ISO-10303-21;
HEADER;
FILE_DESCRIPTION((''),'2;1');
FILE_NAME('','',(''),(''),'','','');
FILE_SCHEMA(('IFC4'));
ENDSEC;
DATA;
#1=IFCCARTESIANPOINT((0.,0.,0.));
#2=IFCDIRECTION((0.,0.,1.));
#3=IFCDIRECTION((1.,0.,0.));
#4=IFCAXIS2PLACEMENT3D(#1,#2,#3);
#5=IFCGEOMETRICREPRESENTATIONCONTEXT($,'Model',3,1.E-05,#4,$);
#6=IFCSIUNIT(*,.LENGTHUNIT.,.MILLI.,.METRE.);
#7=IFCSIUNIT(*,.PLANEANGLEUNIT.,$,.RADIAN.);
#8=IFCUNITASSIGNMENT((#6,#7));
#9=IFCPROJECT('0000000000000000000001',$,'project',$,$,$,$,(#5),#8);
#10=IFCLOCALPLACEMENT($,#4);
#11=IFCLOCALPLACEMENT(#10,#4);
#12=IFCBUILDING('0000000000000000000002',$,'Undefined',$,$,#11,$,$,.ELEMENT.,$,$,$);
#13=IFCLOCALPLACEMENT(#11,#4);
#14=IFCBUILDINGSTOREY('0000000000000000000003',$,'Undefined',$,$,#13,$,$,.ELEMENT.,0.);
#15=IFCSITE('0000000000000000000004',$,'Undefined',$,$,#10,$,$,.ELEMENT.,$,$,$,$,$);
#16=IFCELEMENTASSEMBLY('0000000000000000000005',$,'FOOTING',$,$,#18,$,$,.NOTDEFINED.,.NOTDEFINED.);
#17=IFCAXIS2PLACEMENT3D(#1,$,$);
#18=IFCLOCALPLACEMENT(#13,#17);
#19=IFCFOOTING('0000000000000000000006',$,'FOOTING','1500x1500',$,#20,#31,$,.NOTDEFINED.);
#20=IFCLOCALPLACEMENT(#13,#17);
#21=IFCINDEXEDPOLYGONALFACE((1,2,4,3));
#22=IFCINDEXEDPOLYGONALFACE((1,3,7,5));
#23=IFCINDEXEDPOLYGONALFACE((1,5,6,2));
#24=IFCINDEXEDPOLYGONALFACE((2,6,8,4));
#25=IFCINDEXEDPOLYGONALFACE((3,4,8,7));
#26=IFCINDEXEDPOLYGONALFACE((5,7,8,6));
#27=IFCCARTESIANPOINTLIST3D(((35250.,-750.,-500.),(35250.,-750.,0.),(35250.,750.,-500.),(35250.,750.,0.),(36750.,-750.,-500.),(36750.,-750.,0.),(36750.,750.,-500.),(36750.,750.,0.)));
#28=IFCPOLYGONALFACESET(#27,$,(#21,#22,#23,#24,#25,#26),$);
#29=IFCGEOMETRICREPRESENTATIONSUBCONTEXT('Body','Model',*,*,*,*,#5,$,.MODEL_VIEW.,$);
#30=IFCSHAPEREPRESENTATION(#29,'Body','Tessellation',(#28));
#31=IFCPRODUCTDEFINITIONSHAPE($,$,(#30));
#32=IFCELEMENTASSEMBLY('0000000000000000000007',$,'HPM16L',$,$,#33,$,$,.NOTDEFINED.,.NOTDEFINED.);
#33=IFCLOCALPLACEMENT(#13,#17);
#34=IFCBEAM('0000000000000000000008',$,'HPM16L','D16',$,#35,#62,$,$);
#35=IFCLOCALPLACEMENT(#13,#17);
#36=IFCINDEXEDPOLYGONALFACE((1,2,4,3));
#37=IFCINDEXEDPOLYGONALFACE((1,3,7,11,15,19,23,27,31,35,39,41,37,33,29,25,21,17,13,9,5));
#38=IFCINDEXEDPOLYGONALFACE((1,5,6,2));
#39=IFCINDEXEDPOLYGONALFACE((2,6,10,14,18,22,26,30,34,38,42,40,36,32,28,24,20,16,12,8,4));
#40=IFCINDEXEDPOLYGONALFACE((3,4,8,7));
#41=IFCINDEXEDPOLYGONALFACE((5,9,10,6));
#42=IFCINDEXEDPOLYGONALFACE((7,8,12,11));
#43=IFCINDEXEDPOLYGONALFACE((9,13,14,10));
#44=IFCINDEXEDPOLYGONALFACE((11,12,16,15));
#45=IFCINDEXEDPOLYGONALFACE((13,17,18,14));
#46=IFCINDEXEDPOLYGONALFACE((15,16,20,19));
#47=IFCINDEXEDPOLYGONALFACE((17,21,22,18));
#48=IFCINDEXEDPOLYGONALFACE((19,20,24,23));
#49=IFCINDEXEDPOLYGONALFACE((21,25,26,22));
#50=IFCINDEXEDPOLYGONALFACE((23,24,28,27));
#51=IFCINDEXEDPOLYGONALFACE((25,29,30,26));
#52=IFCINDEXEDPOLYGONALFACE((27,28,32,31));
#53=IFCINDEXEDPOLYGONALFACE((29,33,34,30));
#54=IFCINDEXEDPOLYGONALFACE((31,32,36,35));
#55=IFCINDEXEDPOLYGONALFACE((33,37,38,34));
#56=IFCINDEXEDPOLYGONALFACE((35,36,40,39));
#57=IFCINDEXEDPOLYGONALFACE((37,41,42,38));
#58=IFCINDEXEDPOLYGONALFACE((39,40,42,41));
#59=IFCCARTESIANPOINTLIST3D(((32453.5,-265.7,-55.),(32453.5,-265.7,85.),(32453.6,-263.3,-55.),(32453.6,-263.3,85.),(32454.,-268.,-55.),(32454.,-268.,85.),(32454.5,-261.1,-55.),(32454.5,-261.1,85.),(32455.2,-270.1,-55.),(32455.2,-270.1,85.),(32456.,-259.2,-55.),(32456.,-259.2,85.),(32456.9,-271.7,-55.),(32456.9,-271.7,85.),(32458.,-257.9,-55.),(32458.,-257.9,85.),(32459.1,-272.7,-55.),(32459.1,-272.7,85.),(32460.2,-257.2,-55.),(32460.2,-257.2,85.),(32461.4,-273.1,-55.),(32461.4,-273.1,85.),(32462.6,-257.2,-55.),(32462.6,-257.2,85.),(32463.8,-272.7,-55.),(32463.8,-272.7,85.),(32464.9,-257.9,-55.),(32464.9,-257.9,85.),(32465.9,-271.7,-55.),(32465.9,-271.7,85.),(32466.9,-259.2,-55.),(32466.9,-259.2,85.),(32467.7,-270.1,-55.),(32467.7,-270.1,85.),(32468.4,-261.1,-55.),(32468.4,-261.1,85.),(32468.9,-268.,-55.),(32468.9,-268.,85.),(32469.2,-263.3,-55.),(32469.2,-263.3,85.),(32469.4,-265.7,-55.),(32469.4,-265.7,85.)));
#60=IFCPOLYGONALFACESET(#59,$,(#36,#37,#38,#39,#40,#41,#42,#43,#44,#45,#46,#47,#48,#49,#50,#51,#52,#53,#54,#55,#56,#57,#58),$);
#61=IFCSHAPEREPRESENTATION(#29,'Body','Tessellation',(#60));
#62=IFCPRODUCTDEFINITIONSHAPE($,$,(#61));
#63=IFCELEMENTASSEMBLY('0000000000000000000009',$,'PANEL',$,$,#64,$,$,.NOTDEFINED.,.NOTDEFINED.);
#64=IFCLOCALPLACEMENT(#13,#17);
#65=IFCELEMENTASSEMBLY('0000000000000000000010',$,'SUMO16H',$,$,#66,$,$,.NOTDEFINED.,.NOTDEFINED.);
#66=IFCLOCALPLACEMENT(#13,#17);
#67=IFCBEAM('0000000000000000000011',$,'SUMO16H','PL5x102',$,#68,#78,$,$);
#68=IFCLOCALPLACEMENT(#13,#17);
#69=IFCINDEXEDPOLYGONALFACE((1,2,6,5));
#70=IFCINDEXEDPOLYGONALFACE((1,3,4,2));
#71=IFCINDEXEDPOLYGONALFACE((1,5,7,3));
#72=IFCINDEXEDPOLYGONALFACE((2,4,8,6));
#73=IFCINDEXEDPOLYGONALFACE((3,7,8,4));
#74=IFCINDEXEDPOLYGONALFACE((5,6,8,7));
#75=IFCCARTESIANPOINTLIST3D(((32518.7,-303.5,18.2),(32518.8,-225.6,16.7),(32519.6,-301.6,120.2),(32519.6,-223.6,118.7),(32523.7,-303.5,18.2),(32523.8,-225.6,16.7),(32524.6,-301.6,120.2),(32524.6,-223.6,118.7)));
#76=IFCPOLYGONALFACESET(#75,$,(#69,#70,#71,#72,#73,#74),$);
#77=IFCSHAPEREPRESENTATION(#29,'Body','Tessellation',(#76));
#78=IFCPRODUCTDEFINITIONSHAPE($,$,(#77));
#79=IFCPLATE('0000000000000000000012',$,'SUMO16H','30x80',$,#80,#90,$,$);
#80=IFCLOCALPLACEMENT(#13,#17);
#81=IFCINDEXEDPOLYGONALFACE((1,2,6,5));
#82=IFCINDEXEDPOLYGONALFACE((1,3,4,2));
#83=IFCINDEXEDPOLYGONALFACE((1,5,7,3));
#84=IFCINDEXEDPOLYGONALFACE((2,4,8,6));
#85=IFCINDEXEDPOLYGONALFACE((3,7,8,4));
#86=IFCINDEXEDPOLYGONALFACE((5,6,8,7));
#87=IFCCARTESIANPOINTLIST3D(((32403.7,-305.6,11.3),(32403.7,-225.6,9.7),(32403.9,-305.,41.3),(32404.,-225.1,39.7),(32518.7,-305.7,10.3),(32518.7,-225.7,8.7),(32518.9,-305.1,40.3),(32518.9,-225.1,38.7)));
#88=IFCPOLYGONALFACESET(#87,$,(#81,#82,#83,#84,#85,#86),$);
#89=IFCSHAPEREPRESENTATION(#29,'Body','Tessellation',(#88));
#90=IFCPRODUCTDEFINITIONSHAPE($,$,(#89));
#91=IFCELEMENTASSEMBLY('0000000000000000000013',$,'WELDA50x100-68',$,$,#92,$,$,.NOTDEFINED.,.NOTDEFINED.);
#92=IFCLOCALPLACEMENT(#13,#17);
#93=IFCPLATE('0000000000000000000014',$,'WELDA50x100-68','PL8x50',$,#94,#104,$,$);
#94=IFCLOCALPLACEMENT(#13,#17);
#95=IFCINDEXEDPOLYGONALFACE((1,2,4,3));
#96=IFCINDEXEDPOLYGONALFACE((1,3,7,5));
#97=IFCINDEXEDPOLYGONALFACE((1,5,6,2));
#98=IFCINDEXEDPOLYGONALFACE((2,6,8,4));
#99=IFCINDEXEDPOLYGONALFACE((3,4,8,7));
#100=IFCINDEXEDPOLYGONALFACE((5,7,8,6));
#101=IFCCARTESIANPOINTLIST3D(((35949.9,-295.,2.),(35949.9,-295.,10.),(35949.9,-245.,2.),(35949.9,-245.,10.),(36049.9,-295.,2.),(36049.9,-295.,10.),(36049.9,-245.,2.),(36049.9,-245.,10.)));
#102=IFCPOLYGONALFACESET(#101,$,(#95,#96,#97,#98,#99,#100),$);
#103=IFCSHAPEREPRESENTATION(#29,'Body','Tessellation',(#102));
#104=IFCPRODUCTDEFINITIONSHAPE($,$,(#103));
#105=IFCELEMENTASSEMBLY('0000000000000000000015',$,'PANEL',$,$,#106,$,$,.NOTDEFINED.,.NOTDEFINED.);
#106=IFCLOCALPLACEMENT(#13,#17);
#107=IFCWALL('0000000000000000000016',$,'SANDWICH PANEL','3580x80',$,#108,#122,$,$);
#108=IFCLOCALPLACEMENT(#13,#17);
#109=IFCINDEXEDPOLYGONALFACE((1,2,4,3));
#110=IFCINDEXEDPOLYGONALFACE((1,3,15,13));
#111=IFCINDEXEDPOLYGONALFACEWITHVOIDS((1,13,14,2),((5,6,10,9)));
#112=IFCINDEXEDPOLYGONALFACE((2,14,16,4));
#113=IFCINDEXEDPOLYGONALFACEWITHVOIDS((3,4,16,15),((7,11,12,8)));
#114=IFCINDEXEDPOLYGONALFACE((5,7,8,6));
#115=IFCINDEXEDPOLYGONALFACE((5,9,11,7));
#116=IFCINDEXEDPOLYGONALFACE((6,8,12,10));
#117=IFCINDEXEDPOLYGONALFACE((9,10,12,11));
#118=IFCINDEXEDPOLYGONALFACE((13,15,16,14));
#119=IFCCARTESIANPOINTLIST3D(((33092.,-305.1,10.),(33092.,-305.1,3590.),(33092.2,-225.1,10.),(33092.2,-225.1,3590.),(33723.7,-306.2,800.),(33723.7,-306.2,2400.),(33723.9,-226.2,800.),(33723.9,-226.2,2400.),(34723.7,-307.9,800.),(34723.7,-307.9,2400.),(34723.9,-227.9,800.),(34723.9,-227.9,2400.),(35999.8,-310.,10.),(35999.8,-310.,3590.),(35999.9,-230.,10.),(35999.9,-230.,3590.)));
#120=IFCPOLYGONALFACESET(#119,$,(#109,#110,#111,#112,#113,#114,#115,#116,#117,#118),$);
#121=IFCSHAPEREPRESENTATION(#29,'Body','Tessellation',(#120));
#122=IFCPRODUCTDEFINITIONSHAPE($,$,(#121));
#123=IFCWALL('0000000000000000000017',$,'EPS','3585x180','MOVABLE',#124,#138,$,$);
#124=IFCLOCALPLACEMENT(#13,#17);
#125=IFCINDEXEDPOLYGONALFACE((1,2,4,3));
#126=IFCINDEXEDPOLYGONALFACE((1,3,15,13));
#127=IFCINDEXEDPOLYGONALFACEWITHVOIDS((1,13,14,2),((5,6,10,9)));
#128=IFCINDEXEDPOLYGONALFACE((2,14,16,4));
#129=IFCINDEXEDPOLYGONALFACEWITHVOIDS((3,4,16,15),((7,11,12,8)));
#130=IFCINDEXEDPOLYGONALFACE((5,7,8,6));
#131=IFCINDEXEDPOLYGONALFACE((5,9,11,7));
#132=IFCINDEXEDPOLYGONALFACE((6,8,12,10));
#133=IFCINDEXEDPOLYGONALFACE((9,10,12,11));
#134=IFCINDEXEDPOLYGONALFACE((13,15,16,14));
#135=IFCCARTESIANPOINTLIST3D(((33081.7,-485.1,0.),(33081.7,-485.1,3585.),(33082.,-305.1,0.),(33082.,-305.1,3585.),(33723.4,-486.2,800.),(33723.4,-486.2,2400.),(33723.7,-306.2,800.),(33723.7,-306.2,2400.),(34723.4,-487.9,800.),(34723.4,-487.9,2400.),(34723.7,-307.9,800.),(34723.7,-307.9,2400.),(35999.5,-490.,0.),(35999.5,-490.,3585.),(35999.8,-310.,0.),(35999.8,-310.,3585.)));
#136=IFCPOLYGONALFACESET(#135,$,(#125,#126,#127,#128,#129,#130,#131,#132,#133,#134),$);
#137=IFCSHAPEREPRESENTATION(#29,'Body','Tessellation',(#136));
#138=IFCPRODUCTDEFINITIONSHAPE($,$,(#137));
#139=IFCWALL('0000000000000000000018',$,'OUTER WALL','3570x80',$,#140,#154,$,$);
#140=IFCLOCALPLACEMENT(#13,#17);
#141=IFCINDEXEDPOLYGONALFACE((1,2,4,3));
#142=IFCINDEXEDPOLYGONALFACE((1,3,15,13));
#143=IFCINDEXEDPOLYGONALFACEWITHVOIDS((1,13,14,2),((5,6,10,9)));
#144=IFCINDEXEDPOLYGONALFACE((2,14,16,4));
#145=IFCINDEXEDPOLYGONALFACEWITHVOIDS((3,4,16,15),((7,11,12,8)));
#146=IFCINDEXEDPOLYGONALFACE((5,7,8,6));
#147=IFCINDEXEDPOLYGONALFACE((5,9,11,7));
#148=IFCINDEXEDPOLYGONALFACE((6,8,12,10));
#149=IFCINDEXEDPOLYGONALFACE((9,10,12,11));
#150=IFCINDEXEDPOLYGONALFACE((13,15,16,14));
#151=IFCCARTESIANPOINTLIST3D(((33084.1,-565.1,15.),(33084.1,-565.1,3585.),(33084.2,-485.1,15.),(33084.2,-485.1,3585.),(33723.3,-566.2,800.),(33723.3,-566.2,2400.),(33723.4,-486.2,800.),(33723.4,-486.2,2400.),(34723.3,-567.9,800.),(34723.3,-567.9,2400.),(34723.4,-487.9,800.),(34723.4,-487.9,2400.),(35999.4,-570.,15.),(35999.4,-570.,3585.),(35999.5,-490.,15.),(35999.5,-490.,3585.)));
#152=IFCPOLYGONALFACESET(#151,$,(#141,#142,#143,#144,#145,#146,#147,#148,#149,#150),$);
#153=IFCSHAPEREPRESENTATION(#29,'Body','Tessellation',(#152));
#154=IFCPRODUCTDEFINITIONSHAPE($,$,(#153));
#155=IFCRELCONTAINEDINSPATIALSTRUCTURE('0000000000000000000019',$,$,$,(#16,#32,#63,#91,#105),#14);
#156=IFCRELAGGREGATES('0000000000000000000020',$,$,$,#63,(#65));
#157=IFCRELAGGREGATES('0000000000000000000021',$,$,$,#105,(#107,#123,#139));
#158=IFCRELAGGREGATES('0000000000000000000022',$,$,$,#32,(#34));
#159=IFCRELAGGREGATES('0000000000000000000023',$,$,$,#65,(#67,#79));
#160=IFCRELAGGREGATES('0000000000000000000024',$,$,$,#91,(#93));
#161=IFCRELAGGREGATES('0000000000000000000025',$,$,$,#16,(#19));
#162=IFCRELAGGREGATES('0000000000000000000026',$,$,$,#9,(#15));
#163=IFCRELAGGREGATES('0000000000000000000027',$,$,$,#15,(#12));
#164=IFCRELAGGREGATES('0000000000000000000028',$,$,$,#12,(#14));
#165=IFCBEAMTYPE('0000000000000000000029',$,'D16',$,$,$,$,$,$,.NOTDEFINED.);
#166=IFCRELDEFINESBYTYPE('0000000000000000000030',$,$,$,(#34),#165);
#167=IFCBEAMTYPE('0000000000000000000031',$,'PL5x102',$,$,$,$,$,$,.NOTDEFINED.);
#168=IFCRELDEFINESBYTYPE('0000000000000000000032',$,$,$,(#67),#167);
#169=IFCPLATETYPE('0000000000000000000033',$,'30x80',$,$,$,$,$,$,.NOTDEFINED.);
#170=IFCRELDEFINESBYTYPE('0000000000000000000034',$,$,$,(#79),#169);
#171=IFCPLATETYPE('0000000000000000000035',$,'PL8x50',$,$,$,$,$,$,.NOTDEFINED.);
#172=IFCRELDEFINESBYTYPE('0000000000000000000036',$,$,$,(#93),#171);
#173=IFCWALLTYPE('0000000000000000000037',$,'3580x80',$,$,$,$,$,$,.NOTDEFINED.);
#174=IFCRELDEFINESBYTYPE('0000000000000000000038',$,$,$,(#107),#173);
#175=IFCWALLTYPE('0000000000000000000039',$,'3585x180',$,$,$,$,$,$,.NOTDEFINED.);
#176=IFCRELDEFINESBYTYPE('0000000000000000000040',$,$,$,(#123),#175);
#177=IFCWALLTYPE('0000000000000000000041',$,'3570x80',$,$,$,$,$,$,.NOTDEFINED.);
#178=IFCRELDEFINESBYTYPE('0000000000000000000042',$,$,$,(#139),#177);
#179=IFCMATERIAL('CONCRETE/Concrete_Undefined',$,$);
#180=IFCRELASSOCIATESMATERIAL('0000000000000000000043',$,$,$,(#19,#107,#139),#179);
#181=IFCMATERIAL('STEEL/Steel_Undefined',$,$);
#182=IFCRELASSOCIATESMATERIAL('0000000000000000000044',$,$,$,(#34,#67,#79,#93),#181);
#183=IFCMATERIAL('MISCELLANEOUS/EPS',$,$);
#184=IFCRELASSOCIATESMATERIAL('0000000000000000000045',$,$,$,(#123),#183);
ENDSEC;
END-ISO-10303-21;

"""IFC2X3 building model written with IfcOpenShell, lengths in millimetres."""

from ifc_helpers import new_model, si_unit, frame, frame_2d, origin_with_axes, origin_2d_with_axis, place, context, subcontext, project, spatial, polyline, rectangle, circle, outline, extrude, material, type_object, element, aggregate, save


model = new_model("IFC2X3")

# Units and contexts
model_context = context("Model", 3, precision=1e-05, world=origin_with_axes())
body_context = subcontext(model_context, "Body", "Model", "MODEL_VIEW")
ifc_project = project(units=[si_unit("LENGTHUNIT", "METRE", prefix="MILLI"), si_unit("PLANEANGLEUNIT", "RADIAN")], contexts=[model_context])

# Site, building, storey
site_placement = place(None, origin_with_axes())
site = spatial("IfcSite", under=ifc_project, at=site_placement, Name="Undefined", CompositionType="ELEMENT")
building_placement = place(site_placement, origin_with_axes())
building = spatial("IfcBuilding", under=site, at=building_placement, Name="Undefined", CompositionType="ELEMENT")
storey_placement = place(building_placement, origin_with_axes())
storey = spatial("IfcBuildingStorey", under=building, at=storey_placement, Name="Undefined", CompositionType="ELEMENT", Elevation=0.0)

# Element assembly, footing
assembly_1_placement = place(storey_placement, origin_with_axes())
assembly_1 = element("IfcElementAssembly", 1, at=assembly_1_placement, inside=storey, Name="FOOTING", AssemblyPlace="NOTDEFINED", PredefinedType="NOTDEFINED")
ifc_material_1 = material(Name="CONCRETE/Concrete_Undefined")
footing_placement = place(assembly_1_placement, frame((36000.0, 0.0, -500.0), z_axis=(0.0, 1.0, 0.0), x_axis=(0.0, 0.0, 1.0)))
footing = element("IfcFooting", 2, at=footing_placement, material=ifc_material_1, Name="FOOTING", Description="1500x1500", PredefinedType="NOTDEFINED", context=body_context, shape_type="SweptSolid", body=[
    extrude(rectangle(XDim=1500.0, YDim=1500.0, at=origin_2d_with_axis()), frame((500.0, 0.0, 0.0), z_axis=(-1.0, 0.0, 0.0), x_axis=(0.0, -1.0, 0.0)), (0.0, 0.0, 1.0), 500.0),
])

# Element assembly, beam
assembly_2_placement = place(storey_placement, origin_with_axes())
assembly_2 = element("IfcElementAssembly", 3, at=assembly_2_placement, inside=storey, Name="HPM16L", AssemblyPlace="NOTDEFINED", PredefinedType="NOTDEFINED")
ifc_material_2 = material(Name="STEEL/Steel_Undefined")
beam_type_1 = type_object("IfcBeamType", Name="D16", PredefinedType="NOTDEFINED")
beam_1_placement = place(assembly_2_placement, frame((32461.4, -265.1, 85.0), z_axis=(1.0, 0.0, 0.0), x_axis=(0.0, 0.0, -1.0)))
beam_1 = element("IfcBeam", 4, at=beam_1_placement, type_object=beam_type_1, material=ifc_material_2, Name="HPM16L", Description="D16", context=body_context, shape_type="SweptSolid", body=[
    extrude(circle(Radius=8.0, at=origin_2d_with_axis()), frame((140.0, 0.0, 0.0), z_axis=(-1.0, 0.0, 0.0), x_axis=(0.0, -1.0, 0.0)), (0.0, 0.0, 1.0), 140.0),
])

# Element assemblies, beam, plate
assembly_3_placement = place(storey_placement, origin_with_axes())
assembly_3 = element("IfcElementAssembly", 5, at=assembly_3_placement, inside=storey, Name="PANEL", AssemblyPlace="NOTDEFINED", PredefinedType="NOTDEFINED")
assembly_4_placement = place(assembly_3_placement, origin_with_axes())
assembly_4 = element("IfcElementAssembly", 6, at=assembly_4_placement, Name="SUMO16H", AssemblyPlace="NOTDEFINED", PredefinedType="NOTDEFINED")
aggregate(assembly_3, [assembly_4])
beam_type_2 = type_object("IfcBeamType", Name="PL5x102", PredefinedType="NOTDEFINED")
beam_2_placement = place(assembly_4_placement, frame((32521.7, -224.6, 67.7), z_axis=(0.008618, 0.019092, 0.999781), x_axis=(-0.000494, -0.999818, 0.019097)))
beam_2 = element("IfcBeam", 7, at=beam_2_placement, type_object=beam_type_2, material=ifc_material_2, Name="SUMO16H", Description="PL5x102", context=body_context, shape_type="SweptSolid", body=[
    extrude(rectangle(XDim=5.0, YDim=102.0, at=origin_2d_with_axis()), frame((78.0, 0.0, 0.0), z_axis=(-1.0, 0.0, 0.0), x_axis=(0.0, -1.0, 0.0)), (0.0, 0.0, 1.0), 78.0),
])
plate_type_1 = type_object("IfcPlateType", Name="30x80", PredefinedType="NOTDEFINED")
plate_1_placement = place(assembly_4_placement, frame((32518.8, -225.4, 23.7), z_axis=(0.008618, 0.019092, 0.999781), x_axis=(-0.999963, 0.000658, 0.008607)))
plate_1 = element("IfcPlate", 8, at=plate_1_placement, type_object=plate_type_1, material=ifc_material_2, Name="SUMO16H", Description="30x80", context=body_context, shape_type="SweptSolid", body=[
    extrude(outline(polyline([(0.0, 0.0), (115.0, 0.0), (115.0, 80.0), (0.0, 80.0), (0.0, 0.0)])), frame((0.0, 0.0, -15.0), z_axis=(0.0, 0.0, 1.0), x_axis=(1.0, 0.0, 0.0)), (0.0, 0.0, 1.0), 30.0),
])

# Element assembly, plate
assembly_5_placement = place(storey_placement, origin_with_axes())
assembly_5 = element("IfcElementAssembly", 9, at=assembly_5_placement, inside=storey, Name="WELDA50x100-68", AssemblyPlace="NOTDEFINED", PredefinedType="NOTDEFINED")
plate_type_2 = type_object("IfcPlateType", Name="PL8x50", PredefinedType="NOTDEFINED")
plate_2_placement = place(assembly_5_placement, frame((35949.9, -295.0, 6.0), z_axis=(0.0, 0.0, 1.0), x_axis=(1.0, 0.0, 0.0)))
plate_2 = element("IfcPlate", 10, at=plate_2_placement, type_object=plate_type_2, material=ifc_material_2, Name="WELDA50x100-68", Description="PL8x50", context=body_context, shape_type="SweptSolid", body=[
    extrude(outline(polyline([(0.0, 0.0), (100.0, 0.0), (100.0, 50.0), (0.0, 50.0), (0.0, 0.0)])), frame((0.0, 0.0, -4.0), z_axis=(0.0, 0.0, 1.0), x_axis=(1.0, 0.0, 0.0)), (0.0, 0.0, 1.0), 8.0),
])

# Element assembly, walls, openings
assembly_6_placement = place(storey_placement, origin_with_axes())
assembly_6 = element("IfcElementAssembly", 11, at=assembly_6_placement, inside=storey, Name="PANEL", AssemblyPlace="NOTDEFINED", PredefinedType="NOTDEFINED")
wall_type_1 = type_object("IfcWallType", Name="3580x80", PredefinedType="NOTDEFINED")
wall_1_placement = place(assembly_6_placement, frame((33092.1, -265.1, 10.0), z_axis=(0.0, 0.0, 1.0), x_axis=(0.999999, -0.001684, 0.0)))
wall_1 = element("IfcWall", 12, at=wall_1_placement, type_object=wall_type_1, material=ifc_material_1, Name="SANDWICH PANEL", Description="3580x80", context=body_context, shape_type="SweptSolid", body=[
    extrude(rectangle(XDim=2907.8, YDim=80.0, at=frame_2d((0.0, 1453.9), x_axis=(0.0, -1.0))), frame((0.0, 0.0, 0.0), z_axis=(0.0, 0.0, 1.0), x_axis=(0.0, -1.0, 0.0)), (0.0, 0.0, 1.0), 3580.0),
])
opening_1_placement = place(assembly_6_placement, frame((33092.1, -265.1, 10.0), z_axis=(0.0, 0.0, 1.0), x_axis=(0.999999, -0.001684, 0.0)))
element("IfcOpeningElement", 13, at=opening_1_placement, cuts=wall_1, ObjectType="Recess", context=body_context, shape_type="SweptSolid", body=[
    extrude(outline(polyline([(0.0, 0.0), (1000.0, 0.0), (1000.0, 1600.0), (0.0, 1600.0), (0.0, 0.0)])), frame((631.7, 90.0, 790.0), z_axis=(0.0, -1.0, 0.0), x_axis=(1.0, 0.0, 0.0)), (0.0, 0.0, 1.0), 180.0),
])
ifc_material_3 = material(Name="MISCELLANEOUS/EPS")
wall_type_2 = type_object("IfcWallType", Name="3585x180", PredefinedType="NOTDEFINED")
wall_2_placement = place(assembly_6_placement, frame((33081.9, -395.1, 0.0), z_axis=(0.0, 0.0, 1.0), x_axis=(0.999999, -0.001684, 0.0)))
wall_2 = element("IfcWall", 14, at=wall_2_placement, type_object=wall_type_2, material=ifc_material_3, Name="EPS", Description="3585x180", ObjectType="MOVABLE", context=body_context, shape_type="SweptSolid", body=[
    extrude(rectangle(XDim=2917.8, YDim=180.0, at=frame_2d((0.0, 1458.9), x_axis=(0.0, -1.0))), frame((0.0, 0.0, 0.0), z_axis=(0.0, 0.0, 1.0), x_axis=(0.0, -1.0, 0.0)), (0.0, 0.0, 1.0), 3585.0),
])
opening_2_placement = place(assembly_6_placement, frame((33081.9, -395.1, 0.0), z_axis=(0.0, 0.0, 1.0), x_axis=(0.999999, -0.001684, 0.0)))
element("IfcOpeningElement", 15, at=opening_2_placement, cuts=wall_2, ObjectType="Recess", context=body_context, shape_type="SweptSolid", body=[
    extrude(outline(polyline([(0.0, 0.0), (1000.0, 0.0), (1000.0, 1600.0), (0.0, 1600.0), (0.0, 0.0)])), frame((641.7, 140.0, 800.0), z_axis=(0.0, -1.0, 0.0), x_axis=(1.0, 0.0, 0.0)), (0.0, 0.0, 1.0), 280.0),
])
wall_type_3 = type_object("IfcWallType", Name="3570x80", PredefinedType="NOTDEFINED")
wall_3_placement = place(assembly_6_placement, frame((33084.1, -525.1, 15.0), z_axis=(0.0, 0.0, 1.0), x_axis=(0.999999, -0.001684, 0.0)))
wall_3 = element("IfcWall", 16, at=wall_3_placement, type_object=wall_type_3, material=ifc_material_1, Name="OUTER WALL", Description="3570x80", context=body_context, shape_type="SweptSolid", body=[
    extrude(rectangle(XDim=2915.3, YDim=80.0, at=frame_2d((0.0, 1457.7), x_axis=(0.0, -1.0))), frame((0.0, 0.0, 0.0), z_axis=(0.0, 0.0, 1.0), x_axis=(0.0, -1.0, 0.0)), (0.0, 0.0, 1.0), 3570.0),
])
opening_3_placement = place(assembly_6_placement, frame((33084.1, -525.1, 15.0), z_axis=(0.0, 0.0, 1.0), x_axis=(0.999999, -0.001684, 0.0)))
element("IfcOpeningElement", 17, at=opening_3_placement, cuts=wall_3, ObjectType="Recess", context=body_context, shape_type="SweptSolid", body=[
    extrude(outline(polyline([(0.0, 0.0), (1000.0, 0.0), (1000.0, 1600.0), (0.0, 1600.0), (0.0, 0.0)])), frame((639.2, 90.0, 785.0), z_axis=(0.0, -1.0, 0.0), x_axis=(1.0, 0.0, 0.0)), (0.0, 0.0, 1.0), 180.0),
])
aggregate(assembly_6, [wall_1, wall_2, wall_3])

aggregate(assembly_2, [beam_1])
aggregate(assembly_4, [beam_2, plate_1])
aggregate(assembly_5, [plate_2])

aggregate(assembly_1, [footing])

save(model, "model.ifc")
